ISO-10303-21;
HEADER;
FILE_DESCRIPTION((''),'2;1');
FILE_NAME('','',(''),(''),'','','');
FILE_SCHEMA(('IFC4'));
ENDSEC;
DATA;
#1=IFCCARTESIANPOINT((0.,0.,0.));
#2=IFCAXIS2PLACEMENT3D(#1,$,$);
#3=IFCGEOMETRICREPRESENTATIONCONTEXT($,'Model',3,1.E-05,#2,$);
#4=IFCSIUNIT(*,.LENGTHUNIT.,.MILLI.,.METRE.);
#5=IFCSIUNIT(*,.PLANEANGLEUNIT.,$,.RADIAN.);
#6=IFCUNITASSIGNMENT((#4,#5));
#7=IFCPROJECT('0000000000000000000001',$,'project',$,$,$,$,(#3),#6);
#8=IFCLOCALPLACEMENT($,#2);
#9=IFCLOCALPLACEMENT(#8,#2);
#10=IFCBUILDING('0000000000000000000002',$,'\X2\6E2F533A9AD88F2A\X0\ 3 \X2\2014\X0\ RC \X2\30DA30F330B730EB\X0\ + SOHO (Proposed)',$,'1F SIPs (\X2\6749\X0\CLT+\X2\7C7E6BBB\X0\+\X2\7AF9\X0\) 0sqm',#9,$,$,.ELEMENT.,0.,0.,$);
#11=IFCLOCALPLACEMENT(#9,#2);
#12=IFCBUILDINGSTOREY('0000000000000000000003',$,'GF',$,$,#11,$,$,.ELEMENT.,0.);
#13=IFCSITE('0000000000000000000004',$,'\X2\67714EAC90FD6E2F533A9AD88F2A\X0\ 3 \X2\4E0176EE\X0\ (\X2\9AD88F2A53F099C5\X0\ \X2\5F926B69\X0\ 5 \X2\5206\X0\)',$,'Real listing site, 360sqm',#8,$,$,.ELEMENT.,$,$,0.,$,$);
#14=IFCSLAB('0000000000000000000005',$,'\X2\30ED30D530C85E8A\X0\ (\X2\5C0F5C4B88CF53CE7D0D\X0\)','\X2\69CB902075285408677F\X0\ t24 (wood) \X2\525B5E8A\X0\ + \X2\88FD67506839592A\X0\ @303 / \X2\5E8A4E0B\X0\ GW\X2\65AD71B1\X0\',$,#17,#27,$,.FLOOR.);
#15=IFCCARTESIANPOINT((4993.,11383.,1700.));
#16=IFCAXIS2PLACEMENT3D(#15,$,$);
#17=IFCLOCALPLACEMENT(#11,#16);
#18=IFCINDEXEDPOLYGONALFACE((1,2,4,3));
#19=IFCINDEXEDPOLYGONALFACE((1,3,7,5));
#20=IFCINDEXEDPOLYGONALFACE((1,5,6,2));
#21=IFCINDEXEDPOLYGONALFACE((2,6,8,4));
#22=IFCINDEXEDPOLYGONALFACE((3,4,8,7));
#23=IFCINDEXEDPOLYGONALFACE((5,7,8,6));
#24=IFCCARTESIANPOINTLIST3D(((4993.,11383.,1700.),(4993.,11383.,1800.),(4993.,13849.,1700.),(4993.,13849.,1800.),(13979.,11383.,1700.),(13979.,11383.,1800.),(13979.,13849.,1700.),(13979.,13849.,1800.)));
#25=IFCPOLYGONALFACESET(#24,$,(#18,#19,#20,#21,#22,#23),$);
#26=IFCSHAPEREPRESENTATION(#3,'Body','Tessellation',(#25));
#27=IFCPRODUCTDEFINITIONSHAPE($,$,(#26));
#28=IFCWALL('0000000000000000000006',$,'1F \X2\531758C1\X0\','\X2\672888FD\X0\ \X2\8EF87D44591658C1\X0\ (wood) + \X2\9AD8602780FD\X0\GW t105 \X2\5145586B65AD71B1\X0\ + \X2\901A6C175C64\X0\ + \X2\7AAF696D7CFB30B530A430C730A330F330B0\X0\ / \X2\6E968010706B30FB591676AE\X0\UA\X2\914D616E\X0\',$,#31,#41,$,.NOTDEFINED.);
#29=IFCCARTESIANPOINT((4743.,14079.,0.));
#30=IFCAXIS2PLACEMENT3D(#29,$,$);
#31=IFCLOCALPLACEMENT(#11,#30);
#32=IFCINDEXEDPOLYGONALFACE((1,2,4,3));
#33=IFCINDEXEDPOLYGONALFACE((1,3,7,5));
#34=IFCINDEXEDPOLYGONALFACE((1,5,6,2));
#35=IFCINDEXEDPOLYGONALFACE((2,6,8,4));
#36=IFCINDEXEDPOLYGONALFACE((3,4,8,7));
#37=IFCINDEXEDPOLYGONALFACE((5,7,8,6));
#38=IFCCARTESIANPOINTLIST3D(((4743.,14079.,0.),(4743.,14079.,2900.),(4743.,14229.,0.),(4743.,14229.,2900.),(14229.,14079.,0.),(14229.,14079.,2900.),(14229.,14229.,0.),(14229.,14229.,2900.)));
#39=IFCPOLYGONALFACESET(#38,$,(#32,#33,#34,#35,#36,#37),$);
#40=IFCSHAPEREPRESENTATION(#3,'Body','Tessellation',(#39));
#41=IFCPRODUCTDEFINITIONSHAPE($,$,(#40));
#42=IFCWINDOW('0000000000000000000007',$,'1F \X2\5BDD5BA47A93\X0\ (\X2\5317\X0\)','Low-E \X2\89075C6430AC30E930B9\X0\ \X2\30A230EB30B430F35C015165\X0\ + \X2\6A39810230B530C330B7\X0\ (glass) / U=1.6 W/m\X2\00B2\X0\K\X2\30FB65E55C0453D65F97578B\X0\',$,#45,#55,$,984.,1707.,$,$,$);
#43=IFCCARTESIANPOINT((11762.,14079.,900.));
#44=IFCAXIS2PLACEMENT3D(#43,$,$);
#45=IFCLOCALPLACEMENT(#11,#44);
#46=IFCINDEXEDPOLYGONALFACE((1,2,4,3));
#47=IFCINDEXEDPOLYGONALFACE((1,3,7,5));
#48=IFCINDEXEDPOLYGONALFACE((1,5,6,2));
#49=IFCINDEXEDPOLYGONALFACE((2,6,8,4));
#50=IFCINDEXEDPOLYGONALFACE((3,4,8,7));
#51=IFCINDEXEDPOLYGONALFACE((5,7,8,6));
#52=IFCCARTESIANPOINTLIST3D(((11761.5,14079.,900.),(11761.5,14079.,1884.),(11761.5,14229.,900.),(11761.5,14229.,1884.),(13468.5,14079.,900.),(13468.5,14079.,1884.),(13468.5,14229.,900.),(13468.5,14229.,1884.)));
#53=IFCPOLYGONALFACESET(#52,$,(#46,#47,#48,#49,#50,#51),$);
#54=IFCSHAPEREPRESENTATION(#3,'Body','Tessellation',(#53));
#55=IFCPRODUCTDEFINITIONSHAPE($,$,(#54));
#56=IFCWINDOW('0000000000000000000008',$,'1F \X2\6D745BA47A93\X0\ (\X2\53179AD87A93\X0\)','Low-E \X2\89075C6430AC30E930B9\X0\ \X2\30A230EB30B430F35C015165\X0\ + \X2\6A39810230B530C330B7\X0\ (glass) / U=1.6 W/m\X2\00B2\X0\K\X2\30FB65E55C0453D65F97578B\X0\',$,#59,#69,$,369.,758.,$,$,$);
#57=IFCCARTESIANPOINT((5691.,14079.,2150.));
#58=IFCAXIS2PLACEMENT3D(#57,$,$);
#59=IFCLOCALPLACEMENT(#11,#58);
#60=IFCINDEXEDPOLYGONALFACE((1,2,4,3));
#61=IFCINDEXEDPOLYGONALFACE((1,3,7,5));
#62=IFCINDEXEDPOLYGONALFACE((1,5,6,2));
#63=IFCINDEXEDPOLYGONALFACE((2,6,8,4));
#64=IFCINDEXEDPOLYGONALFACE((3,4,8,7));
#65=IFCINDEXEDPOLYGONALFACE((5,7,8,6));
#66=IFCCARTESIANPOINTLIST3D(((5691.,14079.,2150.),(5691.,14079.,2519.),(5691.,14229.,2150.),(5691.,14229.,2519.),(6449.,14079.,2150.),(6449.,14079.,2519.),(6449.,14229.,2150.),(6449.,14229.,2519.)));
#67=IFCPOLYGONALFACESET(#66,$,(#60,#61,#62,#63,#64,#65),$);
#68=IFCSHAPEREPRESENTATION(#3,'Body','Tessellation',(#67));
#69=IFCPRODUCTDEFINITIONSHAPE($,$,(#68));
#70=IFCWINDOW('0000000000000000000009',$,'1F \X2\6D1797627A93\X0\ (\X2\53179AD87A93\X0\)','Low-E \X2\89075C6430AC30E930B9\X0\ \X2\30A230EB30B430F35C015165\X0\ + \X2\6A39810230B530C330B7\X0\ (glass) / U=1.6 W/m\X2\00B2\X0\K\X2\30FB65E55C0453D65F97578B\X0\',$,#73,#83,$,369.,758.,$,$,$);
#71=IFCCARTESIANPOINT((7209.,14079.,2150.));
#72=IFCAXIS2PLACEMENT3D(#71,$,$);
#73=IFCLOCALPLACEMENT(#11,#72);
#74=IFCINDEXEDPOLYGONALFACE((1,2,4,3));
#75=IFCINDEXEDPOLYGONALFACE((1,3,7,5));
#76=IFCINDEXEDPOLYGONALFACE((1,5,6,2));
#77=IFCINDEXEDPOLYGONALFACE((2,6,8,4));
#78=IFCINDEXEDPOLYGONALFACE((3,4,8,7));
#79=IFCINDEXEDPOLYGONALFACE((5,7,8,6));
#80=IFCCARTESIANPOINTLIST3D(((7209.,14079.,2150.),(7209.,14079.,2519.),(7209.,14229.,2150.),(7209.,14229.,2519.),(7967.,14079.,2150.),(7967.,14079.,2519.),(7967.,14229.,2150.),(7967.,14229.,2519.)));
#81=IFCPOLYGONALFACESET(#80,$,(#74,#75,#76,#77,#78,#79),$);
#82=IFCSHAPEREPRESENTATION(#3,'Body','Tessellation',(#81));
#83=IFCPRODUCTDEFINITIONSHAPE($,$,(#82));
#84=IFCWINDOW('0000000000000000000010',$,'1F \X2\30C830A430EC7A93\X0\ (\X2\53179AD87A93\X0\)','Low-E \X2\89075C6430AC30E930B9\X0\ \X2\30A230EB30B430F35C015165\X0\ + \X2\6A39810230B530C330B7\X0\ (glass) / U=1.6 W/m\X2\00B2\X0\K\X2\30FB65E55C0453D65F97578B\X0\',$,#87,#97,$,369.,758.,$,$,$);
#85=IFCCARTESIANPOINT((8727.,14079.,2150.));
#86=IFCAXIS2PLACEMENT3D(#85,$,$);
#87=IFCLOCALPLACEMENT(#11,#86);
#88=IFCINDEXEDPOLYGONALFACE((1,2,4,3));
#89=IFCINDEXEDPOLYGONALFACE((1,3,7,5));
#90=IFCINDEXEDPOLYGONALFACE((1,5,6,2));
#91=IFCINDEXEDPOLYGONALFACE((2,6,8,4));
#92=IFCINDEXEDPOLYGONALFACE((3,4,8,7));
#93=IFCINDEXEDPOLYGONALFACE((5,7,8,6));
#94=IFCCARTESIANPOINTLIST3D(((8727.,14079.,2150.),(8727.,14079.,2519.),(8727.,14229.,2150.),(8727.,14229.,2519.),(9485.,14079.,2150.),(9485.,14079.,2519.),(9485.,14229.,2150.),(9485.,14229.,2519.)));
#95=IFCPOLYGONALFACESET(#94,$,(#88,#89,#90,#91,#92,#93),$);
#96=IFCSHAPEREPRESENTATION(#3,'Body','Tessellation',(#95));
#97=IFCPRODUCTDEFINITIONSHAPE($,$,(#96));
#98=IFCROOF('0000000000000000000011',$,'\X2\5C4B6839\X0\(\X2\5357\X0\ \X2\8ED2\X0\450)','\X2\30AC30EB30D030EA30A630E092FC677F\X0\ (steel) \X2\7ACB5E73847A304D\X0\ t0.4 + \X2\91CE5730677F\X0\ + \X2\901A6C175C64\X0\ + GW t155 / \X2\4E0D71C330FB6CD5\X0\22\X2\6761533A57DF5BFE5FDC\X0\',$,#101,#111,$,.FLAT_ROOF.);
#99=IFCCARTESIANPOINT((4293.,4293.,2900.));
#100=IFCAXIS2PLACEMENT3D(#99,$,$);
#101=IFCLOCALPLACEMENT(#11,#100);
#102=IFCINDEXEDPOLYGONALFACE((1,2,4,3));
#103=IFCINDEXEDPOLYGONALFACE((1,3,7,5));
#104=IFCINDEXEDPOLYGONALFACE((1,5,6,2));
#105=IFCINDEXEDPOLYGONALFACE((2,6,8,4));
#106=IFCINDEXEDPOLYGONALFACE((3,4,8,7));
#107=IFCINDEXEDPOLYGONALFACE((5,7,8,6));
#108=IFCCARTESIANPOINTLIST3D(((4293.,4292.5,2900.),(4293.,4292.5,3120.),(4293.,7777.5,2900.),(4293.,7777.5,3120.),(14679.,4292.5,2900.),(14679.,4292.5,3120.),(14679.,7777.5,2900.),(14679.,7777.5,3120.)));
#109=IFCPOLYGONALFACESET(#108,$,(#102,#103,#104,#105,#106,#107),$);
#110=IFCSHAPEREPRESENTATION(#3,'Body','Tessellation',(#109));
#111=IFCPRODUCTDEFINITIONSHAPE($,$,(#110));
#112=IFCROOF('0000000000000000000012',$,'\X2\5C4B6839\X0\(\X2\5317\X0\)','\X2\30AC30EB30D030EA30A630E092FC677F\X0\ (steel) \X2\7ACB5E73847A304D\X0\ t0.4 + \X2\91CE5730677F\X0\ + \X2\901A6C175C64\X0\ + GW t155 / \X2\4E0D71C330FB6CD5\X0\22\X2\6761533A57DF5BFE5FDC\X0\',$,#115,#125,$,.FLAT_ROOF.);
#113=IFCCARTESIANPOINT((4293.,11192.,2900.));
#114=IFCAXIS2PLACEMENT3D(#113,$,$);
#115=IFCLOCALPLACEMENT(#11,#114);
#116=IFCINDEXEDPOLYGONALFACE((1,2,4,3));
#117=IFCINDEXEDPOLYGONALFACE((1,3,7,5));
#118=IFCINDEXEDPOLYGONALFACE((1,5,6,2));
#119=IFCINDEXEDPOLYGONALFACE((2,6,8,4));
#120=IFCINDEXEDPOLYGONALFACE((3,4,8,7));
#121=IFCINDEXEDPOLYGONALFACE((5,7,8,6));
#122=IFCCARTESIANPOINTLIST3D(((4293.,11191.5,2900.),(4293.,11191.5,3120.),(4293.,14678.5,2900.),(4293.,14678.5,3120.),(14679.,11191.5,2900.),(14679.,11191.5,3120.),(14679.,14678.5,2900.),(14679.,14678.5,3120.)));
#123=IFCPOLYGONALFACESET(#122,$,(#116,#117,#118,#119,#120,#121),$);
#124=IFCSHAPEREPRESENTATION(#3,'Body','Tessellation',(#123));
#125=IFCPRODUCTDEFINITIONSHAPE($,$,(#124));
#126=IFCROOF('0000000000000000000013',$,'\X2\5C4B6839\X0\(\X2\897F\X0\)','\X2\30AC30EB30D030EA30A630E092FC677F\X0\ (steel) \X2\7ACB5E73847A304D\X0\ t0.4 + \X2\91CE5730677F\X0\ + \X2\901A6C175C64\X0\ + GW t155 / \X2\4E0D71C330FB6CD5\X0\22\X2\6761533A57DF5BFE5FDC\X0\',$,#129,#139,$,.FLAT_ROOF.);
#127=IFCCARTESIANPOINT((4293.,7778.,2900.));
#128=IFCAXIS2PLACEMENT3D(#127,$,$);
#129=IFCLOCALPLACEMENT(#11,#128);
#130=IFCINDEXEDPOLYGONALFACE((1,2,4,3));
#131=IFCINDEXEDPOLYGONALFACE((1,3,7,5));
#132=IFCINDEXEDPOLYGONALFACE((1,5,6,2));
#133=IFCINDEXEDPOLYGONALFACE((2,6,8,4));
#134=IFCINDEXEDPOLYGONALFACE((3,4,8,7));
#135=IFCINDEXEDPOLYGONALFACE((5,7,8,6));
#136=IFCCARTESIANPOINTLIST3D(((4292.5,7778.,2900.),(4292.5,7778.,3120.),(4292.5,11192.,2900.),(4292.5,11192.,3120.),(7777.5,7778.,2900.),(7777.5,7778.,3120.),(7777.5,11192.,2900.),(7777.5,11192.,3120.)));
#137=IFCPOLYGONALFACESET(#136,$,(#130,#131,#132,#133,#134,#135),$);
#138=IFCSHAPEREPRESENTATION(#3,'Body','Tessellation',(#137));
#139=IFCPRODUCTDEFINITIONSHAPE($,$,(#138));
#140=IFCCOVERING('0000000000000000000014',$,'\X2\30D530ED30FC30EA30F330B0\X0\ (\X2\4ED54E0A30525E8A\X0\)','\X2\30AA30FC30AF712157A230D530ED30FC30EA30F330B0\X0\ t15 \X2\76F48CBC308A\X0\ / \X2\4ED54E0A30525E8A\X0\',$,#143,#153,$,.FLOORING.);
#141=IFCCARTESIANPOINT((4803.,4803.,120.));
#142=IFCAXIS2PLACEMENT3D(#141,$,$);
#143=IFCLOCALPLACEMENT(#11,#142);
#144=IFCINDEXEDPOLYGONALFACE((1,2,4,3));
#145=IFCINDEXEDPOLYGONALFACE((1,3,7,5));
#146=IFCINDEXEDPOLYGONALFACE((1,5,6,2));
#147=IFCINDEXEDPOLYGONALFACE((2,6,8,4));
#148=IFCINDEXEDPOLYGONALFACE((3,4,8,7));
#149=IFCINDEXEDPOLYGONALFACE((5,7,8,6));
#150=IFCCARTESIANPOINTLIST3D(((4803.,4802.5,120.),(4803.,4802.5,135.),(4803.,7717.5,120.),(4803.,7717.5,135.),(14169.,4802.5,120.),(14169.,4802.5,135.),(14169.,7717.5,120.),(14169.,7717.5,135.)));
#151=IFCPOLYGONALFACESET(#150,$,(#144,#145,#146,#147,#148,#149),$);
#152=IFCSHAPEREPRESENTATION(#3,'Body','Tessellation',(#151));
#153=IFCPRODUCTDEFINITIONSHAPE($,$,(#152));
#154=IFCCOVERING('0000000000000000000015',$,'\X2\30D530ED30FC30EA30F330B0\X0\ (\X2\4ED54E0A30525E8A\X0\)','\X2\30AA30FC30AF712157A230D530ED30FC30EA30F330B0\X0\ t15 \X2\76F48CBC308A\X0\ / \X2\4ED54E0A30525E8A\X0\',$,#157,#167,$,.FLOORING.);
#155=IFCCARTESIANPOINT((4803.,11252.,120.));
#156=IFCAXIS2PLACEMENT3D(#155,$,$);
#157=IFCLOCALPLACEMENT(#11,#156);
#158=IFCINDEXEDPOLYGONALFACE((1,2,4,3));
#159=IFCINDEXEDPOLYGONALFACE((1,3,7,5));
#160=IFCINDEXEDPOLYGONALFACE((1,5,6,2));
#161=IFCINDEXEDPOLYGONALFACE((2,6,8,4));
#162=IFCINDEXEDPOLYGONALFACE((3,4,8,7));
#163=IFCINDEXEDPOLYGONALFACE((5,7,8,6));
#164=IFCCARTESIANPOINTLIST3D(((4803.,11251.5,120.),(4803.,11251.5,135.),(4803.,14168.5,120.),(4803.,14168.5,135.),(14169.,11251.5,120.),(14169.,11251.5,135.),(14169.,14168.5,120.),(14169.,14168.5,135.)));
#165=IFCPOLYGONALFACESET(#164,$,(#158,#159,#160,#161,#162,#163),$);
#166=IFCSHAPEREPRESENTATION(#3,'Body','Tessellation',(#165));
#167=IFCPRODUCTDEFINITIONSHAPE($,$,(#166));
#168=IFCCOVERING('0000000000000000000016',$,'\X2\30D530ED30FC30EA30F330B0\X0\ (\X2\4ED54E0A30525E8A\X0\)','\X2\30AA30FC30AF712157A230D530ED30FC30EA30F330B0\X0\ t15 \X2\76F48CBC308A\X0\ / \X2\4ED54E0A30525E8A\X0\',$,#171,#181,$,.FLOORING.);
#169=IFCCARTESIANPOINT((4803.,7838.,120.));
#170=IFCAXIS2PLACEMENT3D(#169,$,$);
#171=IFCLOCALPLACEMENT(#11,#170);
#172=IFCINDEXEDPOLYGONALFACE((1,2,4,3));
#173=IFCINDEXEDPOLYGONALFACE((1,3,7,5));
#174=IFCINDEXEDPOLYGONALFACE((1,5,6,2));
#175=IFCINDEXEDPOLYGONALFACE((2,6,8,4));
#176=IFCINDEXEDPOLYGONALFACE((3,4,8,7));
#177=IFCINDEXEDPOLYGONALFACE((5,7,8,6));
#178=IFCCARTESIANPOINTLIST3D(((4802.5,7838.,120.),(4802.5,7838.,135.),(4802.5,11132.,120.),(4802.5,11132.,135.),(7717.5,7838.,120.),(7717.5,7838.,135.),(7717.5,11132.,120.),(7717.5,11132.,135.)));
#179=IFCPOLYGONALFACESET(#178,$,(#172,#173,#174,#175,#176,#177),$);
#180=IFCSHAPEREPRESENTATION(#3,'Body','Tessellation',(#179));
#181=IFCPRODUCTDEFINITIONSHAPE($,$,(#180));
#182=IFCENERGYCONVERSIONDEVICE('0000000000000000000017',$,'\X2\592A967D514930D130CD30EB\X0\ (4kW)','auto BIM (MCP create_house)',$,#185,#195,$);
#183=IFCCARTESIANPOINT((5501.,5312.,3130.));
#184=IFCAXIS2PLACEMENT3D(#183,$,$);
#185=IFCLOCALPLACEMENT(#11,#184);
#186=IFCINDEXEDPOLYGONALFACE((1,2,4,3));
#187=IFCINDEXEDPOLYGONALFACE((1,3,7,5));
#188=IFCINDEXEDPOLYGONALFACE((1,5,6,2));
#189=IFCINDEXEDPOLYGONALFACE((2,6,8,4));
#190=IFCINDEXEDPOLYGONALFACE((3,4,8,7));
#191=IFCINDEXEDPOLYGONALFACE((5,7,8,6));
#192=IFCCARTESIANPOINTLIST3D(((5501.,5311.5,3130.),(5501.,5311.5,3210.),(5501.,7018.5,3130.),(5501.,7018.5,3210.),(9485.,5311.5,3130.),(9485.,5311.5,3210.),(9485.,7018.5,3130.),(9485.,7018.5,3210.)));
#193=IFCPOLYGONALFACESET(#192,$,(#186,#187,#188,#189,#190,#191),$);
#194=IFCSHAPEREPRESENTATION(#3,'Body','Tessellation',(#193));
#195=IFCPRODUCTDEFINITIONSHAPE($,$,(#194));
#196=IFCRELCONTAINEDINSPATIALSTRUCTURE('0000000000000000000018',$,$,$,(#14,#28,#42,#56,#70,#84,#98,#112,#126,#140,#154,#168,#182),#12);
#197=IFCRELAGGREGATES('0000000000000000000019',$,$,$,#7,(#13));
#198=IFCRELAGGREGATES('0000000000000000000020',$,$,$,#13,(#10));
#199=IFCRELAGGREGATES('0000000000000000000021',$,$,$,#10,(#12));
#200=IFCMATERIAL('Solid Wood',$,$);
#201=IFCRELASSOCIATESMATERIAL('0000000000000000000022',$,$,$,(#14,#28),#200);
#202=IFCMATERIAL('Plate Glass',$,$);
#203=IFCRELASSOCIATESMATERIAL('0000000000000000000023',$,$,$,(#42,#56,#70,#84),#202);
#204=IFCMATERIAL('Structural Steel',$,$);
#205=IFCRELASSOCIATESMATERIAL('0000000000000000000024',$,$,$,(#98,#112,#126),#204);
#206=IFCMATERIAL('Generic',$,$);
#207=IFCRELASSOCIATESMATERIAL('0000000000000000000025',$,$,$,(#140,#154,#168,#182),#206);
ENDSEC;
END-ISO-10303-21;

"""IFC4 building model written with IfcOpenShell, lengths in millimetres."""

from ifc_helpers import new_model, si_unit, frame, frame_2d, origin, place, context, project, spatial, rectangle, extrude, material, element, fill, save


model = new_model("IFC4")

# Units and contexts
model_context = context("Model", 3, precision=1e-05, world=origin())
ifc_project = project(units=[si_unit("LENGTHUNIT", "METRE", prefix="MILLI"), si_unit("PLANEANGLEUNIT", "RADIAN")], contexts=[model_context])

# Site, building, storey
site_placement = place(None, origin())
site = spatial("IfcSite", under=ifc_project, at=site_placement, Name="東京都港区高輪 3 丁目 (高輪台駅 徒歩 5 分)", ObjectType="Real listing site, 360sqm", CompositionType="ELEMENT", RefElevation=0.0)
building_placement = place(site_placement, origin())
building = spatial("IfcBuilding", under=site, at=building_placement, Name="港区高輪 3 — RC ペンシル + SOHO (Proposed)", ObjectType="1F SIPs (杉CLT+籾殻+竹) 0sqm", CompositionType="ELEMENT", ElevationOfRefHeight=0.0, ElevationOfTerrain=0.0)
storey_placement = place(building_placement, origin())
storey = spatial("IfcBuildingStorey", under=building, at=storey_placement, Name="GF", CompositionType="ELEMENT", Elevation=0.0)

# Slab
ifc_material_1 = material(Name="Solid Wood")
slab_1_placement = place(storey_placement, frame((4993.0, 11383.0, 1700.0)))
element("IfcSlab", 1, at=slab_1_placement, inside=storey, material=ifc_material_1, Name="ロフト床 (小屋裏収納)", Description="構造用合板 t24 (wood) 剛床 + 製材根太 @303 / 床下 GW断熱", PredefinedType="FLOOR", context=model_context, shape_type="SweptSolid", body=[
    extrude(rectangle(XDim=8986.0, YDim=2466.0, at=frame_2d((4493.0, 1233.0))), frame((4993.0, 11383.0, 1700.0)), (0.0, 0.0, 1.0), 100.0),
])

# Shared definitions
ifc_material_2 = material(Name="Plate Glass")

# Wall, openings, windows
wall_1_placement = place(storey_placement, frame((4743.0, 14079.0, 0.0)))
wall_1 = element("IfcWall", 2, at=wall_1_placement, inside=storey, material=ifc_material_1, Name="1F 北壁", Description="木製 軸組外壁 (wood) + 高性能GW t105 充填断熱 + 通気層 + 窯業系サイディング / 準耐火・外皮UA配慮", PredefinedType="NOTDEFINED", context=model_context, shape_type="SweptSolid", body=[
    extrude(rectangle(XDim=9486.0, YDim=150.0, at=frame_2d((4743.0, 75.0))), frame((4743.0, 14079.0, 0.0)), (0.0, 0.0, 1.0), 2900.0),
])
opening_1_placement = place(storey_placement, frame((11762.0, 14079.0, 900.0)))
opening_1 = element("IfcOpeningElement", 3, at=opening_1_placement, cuts=wall_1, PredefinedType="NOTDEFINED", context=model_context, shape_type="SweptSolid", body=[
    extrude(rectangle(XDim=1707.0, YDim=150.0, at=frame_2d((853.0, 75.0))), frame((11762.0, 14079.0, 900.0)), (0.0, 0.0, 1.0), 984.0),
])
opening_2_placement = place(storey_placement, frame((5691.0, 14079.0, 2150.0)))
opening_2 = element("IfcOpeningElement", 4, at=opening_2_placement, cuts=wall_1, PredefinedType="NOTDEFINED", context=model_context, shape_type="SweptSolid", body=[
    extrude(rectangle(XDim=758.0, YDim=150.0, at=frame_2d((379.0, 75.0))), frame((5691.0, 14079.0, 2150.0)), (0.0, 0.0, 1.0), 369.0),
])
opening_3_placement = place(storey_placement, frame((7209.0, 14079.0, 2150.0)))
opening_3 = element("IfcOpeningElement", 5, at=opening_3_placement, cuts=wall_1, PredefinedType="NOTDEFINED", context=model_context, shape_type="SweptSolid", body=[
    extrude(rectangle(XDim=758.0, YDim=150.0, at=frame_2d((379.0, 75.0))), frame((7209.0, 14079.0, 2150.0)), (0.0, 0.0, 1.0), 369.0),
])
opening_4_placement = place(storey_placement, frame((8727.0, 14079.0, 2150.0)))
opening_4 = element("IfcOpeningElement", 6, at=opening_4_placement, cuts=wall_1, PredefinedType="NOTDEFINED", context=model_context, shape_type="SweptSolid", body=[
    extrude(rectangle(XDim=758.0, YDim=150.0, at=frame_2d((379.0, 75.0))), frame((8727.0, 14079.0, 2150.0)), (0.0, 0.0, 1.0), 369.0),
])
window_1_placement = place(storey_placement, frame((11762.0, 14079.0, 900.0)))
window_1 = element("IfcWindow", 7, at=window_1_placement, inside=storey, material=ifc_material_2, Name="1F 寝室窓 (北)", Description="Low-E 複層ガラス アルゴン封入 + 樹脂サッシ (glass) / U=1.6 W/m²K・日射取得型", OverallHeight=984.0, OverallWidth=1707.0, context=model_context, shape_type="SweptSolid", body=[
    extrude(rectangle(XDim=1707.0, YDim=150.0, at=frame_2d((853.0, 75.0))), frame((11762.0, 14079.0, 900.0)), (0.0, 0.0, 1.0), 984.0),
])
fill(opening_1, window_1)
window_2_placement = place(storey_placement, frame((5691.0, 14079.0, 2150.0)))
window_2 = element("IfcWindow", 8, at=window_2_placement, inside=storey, material=ifc_material_2, Name="1F 浴室窓 (北高窓)", Description="Low-E 複層ガラス アルゴン封入 + 樹脂サッシ (glass) / U=1.6 W/m²K・日射取得型", OverallHeight=369.0, OverallWidth=758.0, context=model_context, shape_type="SweptSolid", body=[
    extrude(rectangle(XDim=758.0, YDim=150.0, at=frame_2d((379.0, 75.0))), frame((5691.0, 14079.0, 2150.0)), (0.0, 0.0, 1.0), 369.0),
])
fill(opening_2, window_2)
window_3_placement = place(storey_placement, frame((7209.0, 14079.0, 2150.0)))
window_3 = element("IfcWindow", 9, at=window_3_placement, inside=storey, material=ifc_material_2, Name="1F 洗面窓 (北高窓)", Description="Low-E 複層ガラス アルゴン封入 + 樹脂サッシ (glass) / U=1.6 W/m²K・日射取得型", OverallHeight=369.0, OverallWidth=758.0, context=model_context, shape_type="SweptSolid", body=[
    extrude(rectangle(XDim=758.0, YDim=150.0, at=frame_2d((379.0, 75.0))), frame((7209.0, 14079.0, 2150.0)), (0.0, 0.0, 1.0), 369.0),
])
fill(opening_3, window_3)
window_4_placement = place(storey_placement, frame((8727.0, 14079.0, 2150.0)))
window_4 = element("IfcWindow", 10, at=window_4_placement, inside=storey, material=ifc_material_2, Name="1F トイレ窓 (北高窓)", Description="Low-E 複層ガラス アルゴン封入 + 樹脂サッシ (glass) / U=1.6 W/m²K・日射取得型", OverallHeight=369.0, OverallWidth=758.0, context=model_context, shape_type="SweptSolid", body=[
    extrude(rectangle(XDim=758.0, YDim=150.0, at=frame_2d((379.0, 75.0))), frame((8727.0, 14079.0, 2150.0)), (0.0, 0.0, 1.0), 369.0),
])
fill(opening_4, window_4)

# Roofs
ifc_material_3 = material(Name="Structural Steel")
roof_1_placement = place(storey_placement, frame((4293.0, 4293.0, 2900.0)))
element("IfcRoof", 11, at=roof_1_placement, inside=storey, material=ifc_material_3, Name="屋根(南 軒450)", Description="ガルバリウム鋼板 (steel) 立平葺き t0.4 + 野地板 + 通気層 + GW t155 / 不燃・法22条区域対応", PredefinedType="FLAT_ROOF", context=model_context, shape_type="SweptSolid", body=[
    extrude(rectangle(XDim=10386.0, YDim=3485.0, at=frame_2d((5193.0, 1742.0))), frame((4293.0, 4293.0, 2900.0)), (0.0, 0.0, 1.0), 220.0),
])
roof_2_placement = place(storey_placement, frame((4293.0, 11192.0, 2900.0)))
element("IfcRoof", 12, at=roof_2_placement, inside=storey, material=ifc_material_3, Name="屋根(北)", Description="ガルバリウム鋼板 (steel) 立平葺き t0.4 + 野地板 + 通気層 + GW t155 / 不燃・法22条区域対応", PredefinedType="FLAT_ROOF", context=model_context, shape_type="SweptSolid", body=[
    extrude(rectangle(XDim=10386.0, YDim=3487.0, at=frame_2d((5193.0, 1743.0))), frame((4293.0, 11192.0, 2900.0)), (0.0, 0.0, 1.0), 220.0),
])
roof_3_placement = place(storey_placement, frame((4293.0, 7778.0, 2900.0)))
element("IfcRoof", 13, at=roof_3_placement, inside=storey, material=ifc_material_3, Name="屋根(西)", Description="ガルバリウム鋼板 (steel) 立平葺き t0.4 + 野地板 + 通気層 + GW t155 / 不燃・法22条区域対応", PredefinedType="FLAT_ROOF", context=model_context, shape_type="SweptSolid", body=[
    extrude(rectangle(XDim=3485.0, YDim=3414.0, at=frame_2d((1742.0, 1707.0))), frame((4293.0, 7778.0, 2900.0)), (0.0, 0.0, 1.0), 220.0),
])

# Coverings
ifc_material_4 = material(Name="Generic")
covering_1_placement = place(storey_placement, frame((4803.0, 4803.0, 120.0)))
element("IfcCovering", 14, at=covering_1_placement, inside=storey, material=ifc_material_4, Name="フローリング (仕上げ床)", Description="オーク無垢フローリング t15 直貼り / 仕上げ床", PredefinedType="FLOORING", context=model_context, shape_type="SweptSolid", body=[
    extrude(rectangle(XDim=9366.0, YDim=2915.0, at=frame_2d((4683.0, 1457.0))), frame((4803.0, 4803.0, 120.0)), (0.0, 0.0, 1.0), 15.0),
])
covering_2_placement = place(storey_placement, frame((4803.0, 11252.0, 120.0)))
element("IfcCovering", 15, at=covering_2_placement, inside=storey, material=ifc_material_4, Name="フローリング (仕上げ床)", Description="オーク無垢フローリング t15 直貼り / 仕上げ床", PredefinedType="FLOORING", context=model_context, shape_type="SweptSolid", body=[
    extrude(rectangle(XDim=9366.0, YDim=2917.0, at=frame_2d((4683.0, 1458.0))), frame((4803.0, 11252.0, 120.0)), (0.0, 0.0, 1.0), 15.0),
])
covering_3_placement = place(storey_placement, frame((4803.0, 7838.0, 120.0)))
element("IfcCovering", 16, at=covering_3_placement, inside=storey, material=ifc_material_4, Name="フローリング (仕上げ床)", Description="オーク無垢フローリング t15 直貼り / 仕上げ床", PredefinedType="FLOORING", context=model_context, shape_type="SweptSolid", body=[
    extrude(rectangle(XDim=2915.0, YDim=3294.0, at=frame_2d((1457.0, 1647.0))), frame((4803.0, 7838.0, 120.0)), (0.0, 0.0, 1.0), 15.0),
])

# Energy conversion device
energy_conversion_device_placement = place(storey_placement, frame((5501.0, 5312.0, 3130.0)))
element("IfcEnergyConversionDevice", 17, at=energy_conversion_device_placement, inside=storey, material=ifc_material_4, Name="太陽光パネル (4kW)", Description="auto BIM (MCP create_house)", context=model_context, shape_type="SweptSolid", body=[
    extrude(rectangle(XDim=3984.0, YDim=1707.0, at=frame_2d((1992.0, 853.0))), frame((5501.0, 5312.0, 3130.0)), (0.0, 0.0, 1.0), 80.0),
])

save(model, "model.ifc")
